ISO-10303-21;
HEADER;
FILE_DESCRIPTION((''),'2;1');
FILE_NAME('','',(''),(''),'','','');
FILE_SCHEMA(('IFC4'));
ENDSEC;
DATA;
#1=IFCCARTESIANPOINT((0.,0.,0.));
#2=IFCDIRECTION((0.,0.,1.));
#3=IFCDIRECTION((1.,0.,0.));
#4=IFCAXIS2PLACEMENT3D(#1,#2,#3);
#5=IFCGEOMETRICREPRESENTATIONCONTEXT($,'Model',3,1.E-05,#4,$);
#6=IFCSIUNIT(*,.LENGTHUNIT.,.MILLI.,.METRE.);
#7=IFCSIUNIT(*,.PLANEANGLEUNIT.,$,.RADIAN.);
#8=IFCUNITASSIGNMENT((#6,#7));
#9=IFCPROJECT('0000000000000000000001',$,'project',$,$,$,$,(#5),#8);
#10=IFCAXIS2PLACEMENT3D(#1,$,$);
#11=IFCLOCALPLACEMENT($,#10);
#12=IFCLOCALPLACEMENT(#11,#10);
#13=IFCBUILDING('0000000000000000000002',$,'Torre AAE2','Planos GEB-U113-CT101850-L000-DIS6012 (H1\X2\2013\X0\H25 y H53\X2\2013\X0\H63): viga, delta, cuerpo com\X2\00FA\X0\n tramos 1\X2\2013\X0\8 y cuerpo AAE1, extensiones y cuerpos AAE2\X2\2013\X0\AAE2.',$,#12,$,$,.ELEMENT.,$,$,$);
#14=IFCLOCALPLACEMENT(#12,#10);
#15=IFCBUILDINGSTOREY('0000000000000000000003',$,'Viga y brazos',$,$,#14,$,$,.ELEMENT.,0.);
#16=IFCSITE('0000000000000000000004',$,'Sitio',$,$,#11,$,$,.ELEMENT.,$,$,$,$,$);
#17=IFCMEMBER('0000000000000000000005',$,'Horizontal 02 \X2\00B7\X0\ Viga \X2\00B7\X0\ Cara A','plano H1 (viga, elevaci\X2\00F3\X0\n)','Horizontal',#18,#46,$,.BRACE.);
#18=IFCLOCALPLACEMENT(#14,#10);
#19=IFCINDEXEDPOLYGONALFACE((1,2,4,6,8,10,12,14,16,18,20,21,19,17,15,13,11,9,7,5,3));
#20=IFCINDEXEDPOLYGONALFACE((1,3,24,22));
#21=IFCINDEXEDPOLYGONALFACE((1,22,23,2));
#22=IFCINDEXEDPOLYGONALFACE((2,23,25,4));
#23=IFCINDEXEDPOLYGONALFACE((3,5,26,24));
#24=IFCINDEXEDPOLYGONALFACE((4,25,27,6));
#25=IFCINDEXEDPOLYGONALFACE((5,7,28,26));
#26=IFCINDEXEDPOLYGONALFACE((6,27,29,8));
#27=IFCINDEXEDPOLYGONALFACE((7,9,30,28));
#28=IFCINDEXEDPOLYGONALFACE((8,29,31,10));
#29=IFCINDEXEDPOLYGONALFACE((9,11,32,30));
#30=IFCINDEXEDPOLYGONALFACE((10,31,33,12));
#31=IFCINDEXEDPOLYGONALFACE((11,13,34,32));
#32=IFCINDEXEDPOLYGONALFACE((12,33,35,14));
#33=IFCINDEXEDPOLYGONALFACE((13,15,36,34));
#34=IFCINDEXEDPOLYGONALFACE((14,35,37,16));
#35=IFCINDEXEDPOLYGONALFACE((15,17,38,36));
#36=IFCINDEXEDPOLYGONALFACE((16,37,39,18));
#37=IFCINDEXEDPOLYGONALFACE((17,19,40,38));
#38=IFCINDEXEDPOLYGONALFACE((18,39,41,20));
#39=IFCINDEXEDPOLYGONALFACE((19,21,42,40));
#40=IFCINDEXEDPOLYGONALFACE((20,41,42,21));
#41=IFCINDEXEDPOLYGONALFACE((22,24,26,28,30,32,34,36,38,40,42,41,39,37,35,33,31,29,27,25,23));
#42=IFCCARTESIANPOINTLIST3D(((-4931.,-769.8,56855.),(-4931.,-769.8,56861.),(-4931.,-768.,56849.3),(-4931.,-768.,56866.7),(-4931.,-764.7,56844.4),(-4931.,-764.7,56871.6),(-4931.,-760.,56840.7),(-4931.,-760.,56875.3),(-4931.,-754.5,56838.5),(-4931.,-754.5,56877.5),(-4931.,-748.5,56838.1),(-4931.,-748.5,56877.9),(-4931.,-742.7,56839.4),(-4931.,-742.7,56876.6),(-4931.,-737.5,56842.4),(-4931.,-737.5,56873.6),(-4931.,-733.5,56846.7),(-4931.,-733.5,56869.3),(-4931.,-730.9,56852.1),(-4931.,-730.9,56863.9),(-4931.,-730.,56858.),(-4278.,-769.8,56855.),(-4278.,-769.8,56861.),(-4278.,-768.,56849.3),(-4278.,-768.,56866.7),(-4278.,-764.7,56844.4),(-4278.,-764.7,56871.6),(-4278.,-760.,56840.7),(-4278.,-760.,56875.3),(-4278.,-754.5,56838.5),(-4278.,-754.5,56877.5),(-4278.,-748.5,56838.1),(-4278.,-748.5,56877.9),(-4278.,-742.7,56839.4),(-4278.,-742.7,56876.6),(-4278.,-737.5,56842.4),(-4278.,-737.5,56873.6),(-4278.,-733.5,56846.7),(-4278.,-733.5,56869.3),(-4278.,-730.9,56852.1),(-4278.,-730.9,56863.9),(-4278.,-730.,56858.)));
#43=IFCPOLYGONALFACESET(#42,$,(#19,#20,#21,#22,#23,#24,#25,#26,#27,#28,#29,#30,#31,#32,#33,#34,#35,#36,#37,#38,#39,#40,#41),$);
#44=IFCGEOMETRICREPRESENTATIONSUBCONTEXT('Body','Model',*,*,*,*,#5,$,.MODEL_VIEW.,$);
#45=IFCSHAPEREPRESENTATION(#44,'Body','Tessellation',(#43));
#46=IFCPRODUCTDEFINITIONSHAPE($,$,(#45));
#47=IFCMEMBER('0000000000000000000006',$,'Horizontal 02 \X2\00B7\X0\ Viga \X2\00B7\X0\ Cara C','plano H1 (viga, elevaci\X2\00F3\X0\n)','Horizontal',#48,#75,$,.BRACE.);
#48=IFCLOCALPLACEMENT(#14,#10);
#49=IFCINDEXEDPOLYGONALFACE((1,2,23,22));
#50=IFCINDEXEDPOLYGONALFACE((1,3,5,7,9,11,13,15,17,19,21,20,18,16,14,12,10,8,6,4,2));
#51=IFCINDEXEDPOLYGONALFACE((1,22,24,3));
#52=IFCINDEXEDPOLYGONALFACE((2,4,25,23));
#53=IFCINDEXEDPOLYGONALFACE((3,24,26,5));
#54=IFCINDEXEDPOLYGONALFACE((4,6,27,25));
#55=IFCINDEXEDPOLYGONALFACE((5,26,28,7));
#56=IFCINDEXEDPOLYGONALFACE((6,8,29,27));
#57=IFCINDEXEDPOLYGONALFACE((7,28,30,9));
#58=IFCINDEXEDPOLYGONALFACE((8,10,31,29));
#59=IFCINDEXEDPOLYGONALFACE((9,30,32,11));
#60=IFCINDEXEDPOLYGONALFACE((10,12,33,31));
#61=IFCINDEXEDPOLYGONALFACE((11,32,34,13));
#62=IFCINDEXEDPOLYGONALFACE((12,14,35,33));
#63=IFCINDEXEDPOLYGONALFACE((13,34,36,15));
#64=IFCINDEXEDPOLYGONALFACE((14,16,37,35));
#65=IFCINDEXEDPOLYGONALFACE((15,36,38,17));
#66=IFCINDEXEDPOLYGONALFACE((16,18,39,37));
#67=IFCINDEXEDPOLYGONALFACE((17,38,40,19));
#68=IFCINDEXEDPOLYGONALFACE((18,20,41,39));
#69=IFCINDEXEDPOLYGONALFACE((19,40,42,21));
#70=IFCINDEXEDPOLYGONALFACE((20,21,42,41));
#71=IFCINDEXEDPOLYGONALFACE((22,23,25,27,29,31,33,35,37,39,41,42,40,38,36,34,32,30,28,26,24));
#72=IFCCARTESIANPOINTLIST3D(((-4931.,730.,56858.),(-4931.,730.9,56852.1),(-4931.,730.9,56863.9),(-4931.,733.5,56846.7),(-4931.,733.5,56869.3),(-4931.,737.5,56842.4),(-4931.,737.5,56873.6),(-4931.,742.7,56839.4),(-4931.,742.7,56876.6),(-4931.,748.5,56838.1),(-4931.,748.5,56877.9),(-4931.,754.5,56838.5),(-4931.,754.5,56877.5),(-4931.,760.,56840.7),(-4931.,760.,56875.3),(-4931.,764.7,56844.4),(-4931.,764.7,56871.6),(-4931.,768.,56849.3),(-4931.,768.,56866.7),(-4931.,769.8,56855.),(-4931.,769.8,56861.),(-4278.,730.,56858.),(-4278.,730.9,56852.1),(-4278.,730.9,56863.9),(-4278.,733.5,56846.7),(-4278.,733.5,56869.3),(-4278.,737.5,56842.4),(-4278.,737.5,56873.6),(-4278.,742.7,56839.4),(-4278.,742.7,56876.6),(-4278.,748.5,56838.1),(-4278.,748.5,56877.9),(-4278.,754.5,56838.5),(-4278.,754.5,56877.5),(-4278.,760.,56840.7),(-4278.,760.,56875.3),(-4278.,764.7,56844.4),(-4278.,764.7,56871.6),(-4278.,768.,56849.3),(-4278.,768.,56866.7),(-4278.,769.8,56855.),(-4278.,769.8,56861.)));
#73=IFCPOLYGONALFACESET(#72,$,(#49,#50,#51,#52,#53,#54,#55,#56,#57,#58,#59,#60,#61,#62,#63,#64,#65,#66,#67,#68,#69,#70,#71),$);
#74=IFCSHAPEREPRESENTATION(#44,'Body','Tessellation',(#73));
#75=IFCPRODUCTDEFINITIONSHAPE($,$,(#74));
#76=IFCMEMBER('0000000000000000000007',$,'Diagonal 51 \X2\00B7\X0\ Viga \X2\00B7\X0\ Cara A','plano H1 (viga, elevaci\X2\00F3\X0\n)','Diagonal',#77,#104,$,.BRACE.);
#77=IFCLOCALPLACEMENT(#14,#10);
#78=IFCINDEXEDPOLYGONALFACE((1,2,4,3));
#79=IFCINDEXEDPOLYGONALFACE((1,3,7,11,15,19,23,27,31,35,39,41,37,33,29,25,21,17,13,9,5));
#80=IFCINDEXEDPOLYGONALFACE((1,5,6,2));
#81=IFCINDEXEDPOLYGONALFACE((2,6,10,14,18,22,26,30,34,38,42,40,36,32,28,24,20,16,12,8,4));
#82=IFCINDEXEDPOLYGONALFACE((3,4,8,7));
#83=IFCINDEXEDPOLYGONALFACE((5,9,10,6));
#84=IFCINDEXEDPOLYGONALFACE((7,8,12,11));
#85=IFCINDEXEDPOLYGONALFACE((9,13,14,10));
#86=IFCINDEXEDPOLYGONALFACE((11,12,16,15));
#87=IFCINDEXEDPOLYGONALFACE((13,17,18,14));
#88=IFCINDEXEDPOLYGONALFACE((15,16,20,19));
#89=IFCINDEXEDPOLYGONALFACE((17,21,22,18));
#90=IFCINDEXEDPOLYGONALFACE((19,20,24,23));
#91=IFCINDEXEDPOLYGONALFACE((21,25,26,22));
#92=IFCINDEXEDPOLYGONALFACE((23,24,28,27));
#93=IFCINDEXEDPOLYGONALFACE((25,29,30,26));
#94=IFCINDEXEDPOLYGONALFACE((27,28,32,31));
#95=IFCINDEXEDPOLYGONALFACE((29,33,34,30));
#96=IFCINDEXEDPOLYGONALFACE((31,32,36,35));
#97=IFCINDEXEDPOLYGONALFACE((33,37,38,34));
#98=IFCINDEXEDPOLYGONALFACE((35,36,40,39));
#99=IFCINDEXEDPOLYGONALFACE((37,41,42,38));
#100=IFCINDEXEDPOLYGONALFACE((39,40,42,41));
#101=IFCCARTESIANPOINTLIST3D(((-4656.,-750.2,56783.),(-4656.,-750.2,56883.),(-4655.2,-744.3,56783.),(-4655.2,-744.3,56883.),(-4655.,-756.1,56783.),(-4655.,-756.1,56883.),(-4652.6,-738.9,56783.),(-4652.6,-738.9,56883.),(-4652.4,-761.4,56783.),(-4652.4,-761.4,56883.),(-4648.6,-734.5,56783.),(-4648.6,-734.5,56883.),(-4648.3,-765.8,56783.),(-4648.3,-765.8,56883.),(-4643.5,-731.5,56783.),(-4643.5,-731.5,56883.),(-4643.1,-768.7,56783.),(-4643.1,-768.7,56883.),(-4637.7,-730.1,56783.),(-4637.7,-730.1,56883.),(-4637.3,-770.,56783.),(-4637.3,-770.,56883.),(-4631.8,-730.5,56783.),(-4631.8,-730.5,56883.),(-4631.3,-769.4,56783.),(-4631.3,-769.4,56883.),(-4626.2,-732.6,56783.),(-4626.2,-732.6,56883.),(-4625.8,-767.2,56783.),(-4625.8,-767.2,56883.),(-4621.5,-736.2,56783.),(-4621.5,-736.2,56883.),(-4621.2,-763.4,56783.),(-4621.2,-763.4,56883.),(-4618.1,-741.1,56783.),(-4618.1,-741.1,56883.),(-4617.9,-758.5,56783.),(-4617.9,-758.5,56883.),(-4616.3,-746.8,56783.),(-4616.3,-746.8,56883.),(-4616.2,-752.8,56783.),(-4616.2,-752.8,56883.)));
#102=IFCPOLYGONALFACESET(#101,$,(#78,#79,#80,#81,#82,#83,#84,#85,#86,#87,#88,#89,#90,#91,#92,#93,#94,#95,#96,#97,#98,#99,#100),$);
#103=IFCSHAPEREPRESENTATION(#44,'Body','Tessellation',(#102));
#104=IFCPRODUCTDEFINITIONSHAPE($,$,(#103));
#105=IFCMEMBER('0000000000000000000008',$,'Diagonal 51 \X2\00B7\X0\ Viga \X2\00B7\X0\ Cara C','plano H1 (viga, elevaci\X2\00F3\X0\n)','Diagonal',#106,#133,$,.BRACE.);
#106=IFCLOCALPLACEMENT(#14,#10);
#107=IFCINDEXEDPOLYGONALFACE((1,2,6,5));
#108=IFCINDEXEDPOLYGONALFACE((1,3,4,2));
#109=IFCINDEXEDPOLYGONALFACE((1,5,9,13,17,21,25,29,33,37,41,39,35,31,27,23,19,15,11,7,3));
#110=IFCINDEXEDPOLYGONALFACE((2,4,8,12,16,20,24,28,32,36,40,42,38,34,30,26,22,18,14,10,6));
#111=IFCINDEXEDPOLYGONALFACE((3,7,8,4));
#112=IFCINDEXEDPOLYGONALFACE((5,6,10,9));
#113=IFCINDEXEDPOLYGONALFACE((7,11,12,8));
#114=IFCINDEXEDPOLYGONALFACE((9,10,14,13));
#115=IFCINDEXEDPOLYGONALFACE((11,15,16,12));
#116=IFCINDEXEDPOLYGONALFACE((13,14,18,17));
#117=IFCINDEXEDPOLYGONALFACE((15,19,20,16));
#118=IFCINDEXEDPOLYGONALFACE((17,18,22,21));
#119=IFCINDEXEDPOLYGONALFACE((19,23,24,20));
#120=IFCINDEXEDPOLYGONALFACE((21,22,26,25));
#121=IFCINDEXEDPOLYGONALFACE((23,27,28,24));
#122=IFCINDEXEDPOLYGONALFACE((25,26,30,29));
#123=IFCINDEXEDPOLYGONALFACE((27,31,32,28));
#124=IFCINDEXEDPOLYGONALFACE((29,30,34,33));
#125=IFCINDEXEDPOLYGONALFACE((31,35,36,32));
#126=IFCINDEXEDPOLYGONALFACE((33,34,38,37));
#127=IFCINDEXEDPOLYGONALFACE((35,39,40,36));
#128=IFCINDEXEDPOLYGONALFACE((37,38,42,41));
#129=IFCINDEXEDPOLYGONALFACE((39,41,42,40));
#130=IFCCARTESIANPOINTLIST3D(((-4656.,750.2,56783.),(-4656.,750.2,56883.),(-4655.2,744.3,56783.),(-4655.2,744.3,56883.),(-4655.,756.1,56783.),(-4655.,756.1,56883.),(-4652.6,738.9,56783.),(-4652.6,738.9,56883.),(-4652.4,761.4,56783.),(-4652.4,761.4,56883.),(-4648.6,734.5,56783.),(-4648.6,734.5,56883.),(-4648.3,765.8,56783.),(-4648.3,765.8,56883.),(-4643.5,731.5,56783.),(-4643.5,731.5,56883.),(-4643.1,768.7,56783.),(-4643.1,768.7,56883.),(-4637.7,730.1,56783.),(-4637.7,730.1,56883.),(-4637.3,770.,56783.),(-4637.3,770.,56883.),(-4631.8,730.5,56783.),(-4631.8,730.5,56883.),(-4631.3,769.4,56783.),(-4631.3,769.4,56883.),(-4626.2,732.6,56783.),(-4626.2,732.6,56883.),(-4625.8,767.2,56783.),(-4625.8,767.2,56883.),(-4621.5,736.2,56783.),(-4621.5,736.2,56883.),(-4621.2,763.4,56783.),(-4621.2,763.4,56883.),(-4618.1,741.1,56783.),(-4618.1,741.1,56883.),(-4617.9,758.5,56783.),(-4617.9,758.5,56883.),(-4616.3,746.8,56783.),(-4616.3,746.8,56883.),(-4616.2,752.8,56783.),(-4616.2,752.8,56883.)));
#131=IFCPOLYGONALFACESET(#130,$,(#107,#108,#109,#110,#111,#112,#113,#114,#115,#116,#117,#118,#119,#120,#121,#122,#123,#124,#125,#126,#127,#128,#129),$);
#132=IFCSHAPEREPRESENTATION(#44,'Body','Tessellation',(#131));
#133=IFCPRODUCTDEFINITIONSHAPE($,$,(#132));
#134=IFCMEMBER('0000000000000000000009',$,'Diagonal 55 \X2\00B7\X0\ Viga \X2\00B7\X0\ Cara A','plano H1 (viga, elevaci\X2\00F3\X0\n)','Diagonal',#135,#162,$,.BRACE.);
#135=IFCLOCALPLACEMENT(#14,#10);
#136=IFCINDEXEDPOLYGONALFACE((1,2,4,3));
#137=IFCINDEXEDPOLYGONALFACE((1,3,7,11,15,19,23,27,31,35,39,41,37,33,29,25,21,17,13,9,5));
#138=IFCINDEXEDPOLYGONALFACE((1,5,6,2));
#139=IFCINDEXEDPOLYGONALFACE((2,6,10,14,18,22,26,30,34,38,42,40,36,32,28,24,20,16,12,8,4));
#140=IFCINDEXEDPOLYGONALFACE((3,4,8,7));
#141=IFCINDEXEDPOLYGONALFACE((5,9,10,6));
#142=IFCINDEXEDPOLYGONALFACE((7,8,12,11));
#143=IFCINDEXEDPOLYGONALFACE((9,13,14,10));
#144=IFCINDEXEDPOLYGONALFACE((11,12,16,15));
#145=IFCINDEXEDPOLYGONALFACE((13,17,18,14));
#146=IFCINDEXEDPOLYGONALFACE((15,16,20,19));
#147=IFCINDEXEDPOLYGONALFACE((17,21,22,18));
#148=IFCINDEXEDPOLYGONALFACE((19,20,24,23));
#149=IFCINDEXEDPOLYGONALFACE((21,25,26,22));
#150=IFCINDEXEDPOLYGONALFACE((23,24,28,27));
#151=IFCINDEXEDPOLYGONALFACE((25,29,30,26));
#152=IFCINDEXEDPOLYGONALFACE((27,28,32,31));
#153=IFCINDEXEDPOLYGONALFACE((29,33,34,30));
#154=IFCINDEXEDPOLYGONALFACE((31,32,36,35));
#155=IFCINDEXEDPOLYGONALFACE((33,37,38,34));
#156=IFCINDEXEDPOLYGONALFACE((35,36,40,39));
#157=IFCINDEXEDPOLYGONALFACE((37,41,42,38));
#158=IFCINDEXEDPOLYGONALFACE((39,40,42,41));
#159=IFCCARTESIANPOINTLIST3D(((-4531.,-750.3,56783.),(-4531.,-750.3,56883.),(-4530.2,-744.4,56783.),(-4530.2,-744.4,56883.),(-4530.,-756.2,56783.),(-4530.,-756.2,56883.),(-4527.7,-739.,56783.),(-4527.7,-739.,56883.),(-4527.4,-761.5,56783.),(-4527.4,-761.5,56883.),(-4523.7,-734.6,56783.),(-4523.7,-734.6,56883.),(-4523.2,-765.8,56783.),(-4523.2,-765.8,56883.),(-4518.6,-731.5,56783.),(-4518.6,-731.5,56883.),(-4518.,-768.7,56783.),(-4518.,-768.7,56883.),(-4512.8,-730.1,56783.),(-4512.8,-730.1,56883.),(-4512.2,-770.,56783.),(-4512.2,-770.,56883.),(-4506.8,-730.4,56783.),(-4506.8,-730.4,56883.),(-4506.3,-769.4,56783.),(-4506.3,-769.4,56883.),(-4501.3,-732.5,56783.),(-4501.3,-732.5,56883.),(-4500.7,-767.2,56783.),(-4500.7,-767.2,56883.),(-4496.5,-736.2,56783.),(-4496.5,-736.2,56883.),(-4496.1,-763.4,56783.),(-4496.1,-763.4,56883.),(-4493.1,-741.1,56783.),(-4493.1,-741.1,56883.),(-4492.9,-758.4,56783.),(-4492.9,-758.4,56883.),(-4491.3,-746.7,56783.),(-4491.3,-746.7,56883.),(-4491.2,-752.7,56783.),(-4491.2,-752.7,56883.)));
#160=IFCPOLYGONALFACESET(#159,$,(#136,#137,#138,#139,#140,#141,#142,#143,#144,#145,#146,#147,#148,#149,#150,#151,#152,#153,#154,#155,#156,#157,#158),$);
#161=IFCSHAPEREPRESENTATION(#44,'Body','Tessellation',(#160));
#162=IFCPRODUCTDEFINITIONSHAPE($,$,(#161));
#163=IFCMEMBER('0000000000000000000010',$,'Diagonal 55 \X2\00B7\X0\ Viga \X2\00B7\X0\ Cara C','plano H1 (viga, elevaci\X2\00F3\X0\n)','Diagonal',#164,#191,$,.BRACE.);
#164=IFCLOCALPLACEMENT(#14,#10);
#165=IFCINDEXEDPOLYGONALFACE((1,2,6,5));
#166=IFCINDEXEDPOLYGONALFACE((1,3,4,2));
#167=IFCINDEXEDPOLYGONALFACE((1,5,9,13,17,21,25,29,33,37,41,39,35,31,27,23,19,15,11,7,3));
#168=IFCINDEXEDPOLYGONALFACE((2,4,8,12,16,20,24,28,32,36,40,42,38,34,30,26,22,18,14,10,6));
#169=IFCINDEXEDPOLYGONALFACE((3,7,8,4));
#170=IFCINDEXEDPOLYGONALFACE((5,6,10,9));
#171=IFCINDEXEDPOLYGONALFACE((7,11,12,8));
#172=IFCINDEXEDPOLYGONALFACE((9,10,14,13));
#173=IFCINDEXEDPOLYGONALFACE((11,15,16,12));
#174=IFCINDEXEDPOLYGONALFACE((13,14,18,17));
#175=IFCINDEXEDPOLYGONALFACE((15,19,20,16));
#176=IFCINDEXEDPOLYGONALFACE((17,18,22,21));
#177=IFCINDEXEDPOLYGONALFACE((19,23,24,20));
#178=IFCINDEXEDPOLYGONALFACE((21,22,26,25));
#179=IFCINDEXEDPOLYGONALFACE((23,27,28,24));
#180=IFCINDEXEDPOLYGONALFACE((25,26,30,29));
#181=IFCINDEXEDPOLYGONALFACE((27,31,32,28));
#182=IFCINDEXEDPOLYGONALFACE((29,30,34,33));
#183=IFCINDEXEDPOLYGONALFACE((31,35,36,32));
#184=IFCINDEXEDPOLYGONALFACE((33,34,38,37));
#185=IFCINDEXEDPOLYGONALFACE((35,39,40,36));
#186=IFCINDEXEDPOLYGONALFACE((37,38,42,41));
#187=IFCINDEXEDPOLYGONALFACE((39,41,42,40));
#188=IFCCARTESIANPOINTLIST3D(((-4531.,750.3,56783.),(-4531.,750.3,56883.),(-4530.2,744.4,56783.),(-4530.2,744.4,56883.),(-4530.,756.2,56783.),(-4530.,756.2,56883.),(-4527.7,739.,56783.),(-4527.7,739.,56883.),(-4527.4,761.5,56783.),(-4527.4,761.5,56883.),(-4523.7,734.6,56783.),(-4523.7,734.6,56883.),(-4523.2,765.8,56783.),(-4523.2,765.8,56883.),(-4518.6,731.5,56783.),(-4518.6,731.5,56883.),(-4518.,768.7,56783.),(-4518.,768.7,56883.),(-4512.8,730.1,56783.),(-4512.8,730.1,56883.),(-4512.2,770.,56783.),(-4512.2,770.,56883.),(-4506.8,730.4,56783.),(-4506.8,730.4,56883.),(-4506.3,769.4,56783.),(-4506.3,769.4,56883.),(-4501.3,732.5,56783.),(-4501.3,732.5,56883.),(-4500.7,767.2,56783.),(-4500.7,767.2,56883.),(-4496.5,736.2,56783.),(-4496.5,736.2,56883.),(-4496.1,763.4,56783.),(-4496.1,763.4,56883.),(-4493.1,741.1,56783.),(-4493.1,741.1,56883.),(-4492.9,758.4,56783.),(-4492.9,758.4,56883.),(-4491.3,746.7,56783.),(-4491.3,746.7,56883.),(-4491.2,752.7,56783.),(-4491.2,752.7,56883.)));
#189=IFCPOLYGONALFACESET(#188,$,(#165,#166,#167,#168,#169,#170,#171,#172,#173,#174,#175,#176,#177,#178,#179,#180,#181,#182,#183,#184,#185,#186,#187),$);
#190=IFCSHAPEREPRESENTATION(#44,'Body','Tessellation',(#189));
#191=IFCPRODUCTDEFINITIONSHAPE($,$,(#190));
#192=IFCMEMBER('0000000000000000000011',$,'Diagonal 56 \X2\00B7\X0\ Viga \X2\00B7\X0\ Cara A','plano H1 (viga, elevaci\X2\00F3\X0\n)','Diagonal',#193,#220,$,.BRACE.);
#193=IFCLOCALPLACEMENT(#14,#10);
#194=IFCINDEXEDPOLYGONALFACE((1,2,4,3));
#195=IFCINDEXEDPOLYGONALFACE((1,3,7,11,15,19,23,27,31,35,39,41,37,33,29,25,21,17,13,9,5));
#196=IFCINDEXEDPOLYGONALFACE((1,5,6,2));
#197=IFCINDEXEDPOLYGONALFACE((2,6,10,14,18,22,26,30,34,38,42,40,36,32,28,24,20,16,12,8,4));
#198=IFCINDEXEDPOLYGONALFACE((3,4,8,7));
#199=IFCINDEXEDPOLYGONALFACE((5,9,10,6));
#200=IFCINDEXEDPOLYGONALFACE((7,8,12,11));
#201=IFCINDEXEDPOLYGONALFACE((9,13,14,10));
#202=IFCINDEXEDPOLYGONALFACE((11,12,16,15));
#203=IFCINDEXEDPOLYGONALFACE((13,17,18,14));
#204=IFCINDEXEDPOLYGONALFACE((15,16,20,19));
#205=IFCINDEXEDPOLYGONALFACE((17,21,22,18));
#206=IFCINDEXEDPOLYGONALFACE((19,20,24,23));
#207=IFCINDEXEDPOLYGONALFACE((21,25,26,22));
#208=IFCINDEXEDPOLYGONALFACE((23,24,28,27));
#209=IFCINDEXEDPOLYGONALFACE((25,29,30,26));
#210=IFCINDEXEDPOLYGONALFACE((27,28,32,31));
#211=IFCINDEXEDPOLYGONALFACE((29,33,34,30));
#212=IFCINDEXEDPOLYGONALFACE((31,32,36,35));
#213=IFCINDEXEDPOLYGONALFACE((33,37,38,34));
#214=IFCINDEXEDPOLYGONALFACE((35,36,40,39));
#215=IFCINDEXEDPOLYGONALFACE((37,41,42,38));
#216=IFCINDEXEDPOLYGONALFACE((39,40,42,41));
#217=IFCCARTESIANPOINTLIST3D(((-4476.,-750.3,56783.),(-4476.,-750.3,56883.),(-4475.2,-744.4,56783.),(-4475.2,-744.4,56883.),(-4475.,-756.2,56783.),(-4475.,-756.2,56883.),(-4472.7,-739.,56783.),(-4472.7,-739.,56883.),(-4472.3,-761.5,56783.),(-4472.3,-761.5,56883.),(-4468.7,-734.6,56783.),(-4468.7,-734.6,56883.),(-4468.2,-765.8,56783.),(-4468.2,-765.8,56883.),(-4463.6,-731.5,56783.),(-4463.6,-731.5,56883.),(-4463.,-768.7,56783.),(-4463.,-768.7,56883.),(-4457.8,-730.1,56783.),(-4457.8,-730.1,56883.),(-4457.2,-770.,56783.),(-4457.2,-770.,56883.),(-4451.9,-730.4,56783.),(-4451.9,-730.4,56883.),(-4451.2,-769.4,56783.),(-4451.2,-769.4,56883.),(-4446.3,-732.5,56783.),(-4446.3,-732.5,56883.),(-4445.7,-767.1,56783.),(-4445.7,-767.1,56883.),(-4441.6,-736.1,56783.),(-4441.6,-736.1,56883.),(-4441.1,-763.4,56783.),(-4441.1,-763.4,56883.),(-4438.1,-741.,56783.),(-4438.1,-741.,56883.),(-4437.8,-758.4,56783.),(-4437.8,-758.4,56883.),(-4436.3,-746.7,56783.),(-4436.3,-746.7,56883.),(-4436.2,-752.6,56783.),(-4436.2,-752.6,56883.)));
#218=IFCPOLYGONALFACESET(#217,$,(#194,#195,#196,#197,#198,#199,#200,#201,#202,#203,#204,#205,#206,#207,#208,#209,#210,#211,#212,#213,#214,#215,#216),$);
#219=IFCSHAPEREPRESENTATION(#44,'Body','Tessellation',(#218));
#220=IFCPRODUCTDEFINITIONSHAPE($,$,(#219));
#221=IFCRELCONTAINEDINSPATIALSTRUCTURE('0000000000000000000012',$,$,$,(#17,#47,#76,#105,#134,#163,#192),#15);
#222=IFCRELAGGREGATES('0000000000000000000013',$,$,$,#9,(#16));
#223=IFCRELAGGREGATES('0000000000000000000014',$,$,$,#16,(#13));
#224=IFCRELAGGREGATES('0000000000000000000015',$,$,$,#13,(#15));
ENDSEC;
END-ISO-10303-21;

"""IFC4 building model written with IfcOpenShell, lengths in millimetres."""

from ifc_helpers import new_model, si_unit, frame, origin, origin_with_axes, place, context, subcontext, project, spatial, circle, extrude, element, save


model = new_model("IFC4")

# Units and contexts
model_context = context("Model", 3, precision=1e-05, world=origin_with_axes())
body_context = subcontext(model_context, "Body", "Model", "MODEL_VIEW")
ifc_project = project(units=[si_unit("LENGTHUNIT", "METRE", prefix="MILLI"), si_unit("PLANEANGLEUNIT", "RADIAN")], contexts=[model_context])

# Site, building, storey
site_placement = place(None, origin())
site = spatial("IfcSite", under=ifc_project, at=site_placement, Name="Sitio", CompositionType="ELEMENT")
building_placement = place(site_placement, origin())
building = spatial("IfcBuilding", under=site, at=building_placement, Name="Torre AAE2", Description="Planos GEB-U113-CT101850-L000-DIS6012 (H1–H25 y H53–H63): viga, delta, cuerpo común tramos 1–8 y cuerpo AAE1, extensiones y cuerpos AAE2–AAE2.", CompositionType="ELEMENT")
storey_placement = place(building_placement, origin())
storey = spatial("IfcBuildingStorey", under=building, at=storey_placement, Name="Viga y brazos", CompositionType="ELEMENT", Elevation=0.0)

# Members
for number, where, z_axis, x_axis, name in (
    (1, (-4931.0, -750.0, 56858.0), (1.0, 0.0, 0.0), (0.0, 1.0, 0.0), "Horizontal 02 · Viga · Cara A"),
    (2, (-4931.0, 750.0, 56858.0), (1.0, 0.0, 0.0), (0.0, -1.0, 0.0), "Horizontal 02 · Viga · Cara C"),
):
    element("IfcMember", number, at=place(storey_placement, frame(where, z_axis=z_axis, x_axis=x_axis)), inside=storey, Name=name, Description="plano H1 (viga, elevación)", ObjectType="Horizontal", PredefinedType="BRACE", context=body_context, shape_type="SweptSolid", body=[
        extrude(circle(Radius=20.0), None, (0.0, 0.0, 1.0), 653.0),
    ])
for number, where, z_axis, x_axis, name in (
    (3, (-4636.0, -750.0, 56883.0), (0.0, 0.0, -1.0), (0.987165, 0.159701, 0.0), "Diagonal 51 · Viga · Cara A"),
    (4, (-4636.0, 750.0, 56883.0), (0.0, 0.0, -1.0), (0.987165, -0.159701, 0.0), "Diagonal 51 · Viga · Cara C"),
    (5, (-4511.0, -750.0, 56883.0), (0.0, 0.0, -1.0), (0.986459, 0.164009, 0.0), "Diagonal 55 · Viga · Cara A"),
    (6, (-4511.0, 750.0, 56883.0), (0.0, 0.0, -1.0), (0.986459, -0.164009, 0.0), "Diagonal 55 · Viga · Cara C"),
    (7, (-4456.0, -750.0, 56883.0), (0.0, 0.0, -1.0), (0.986129, 0.165978, 0.0), "Diagonal 56 · Viga · Cara A"),
):
    element("IfcMember", number, at=place(storey_placement, frame(where, z_axis=z_axis, x_axis=x_axis)), inside=storey, Name=name, Description="plano H1 (viga, elevación)", ObjectType="Diagonal", PredefinedType="BRACE", context=body_context, shape_type="SweptSolid", body=[
        extrude(circle(Radius=20.0), None, (0.0, 0.0, 1.0), 100.0),
    ])

save(model, "model.ifc")
